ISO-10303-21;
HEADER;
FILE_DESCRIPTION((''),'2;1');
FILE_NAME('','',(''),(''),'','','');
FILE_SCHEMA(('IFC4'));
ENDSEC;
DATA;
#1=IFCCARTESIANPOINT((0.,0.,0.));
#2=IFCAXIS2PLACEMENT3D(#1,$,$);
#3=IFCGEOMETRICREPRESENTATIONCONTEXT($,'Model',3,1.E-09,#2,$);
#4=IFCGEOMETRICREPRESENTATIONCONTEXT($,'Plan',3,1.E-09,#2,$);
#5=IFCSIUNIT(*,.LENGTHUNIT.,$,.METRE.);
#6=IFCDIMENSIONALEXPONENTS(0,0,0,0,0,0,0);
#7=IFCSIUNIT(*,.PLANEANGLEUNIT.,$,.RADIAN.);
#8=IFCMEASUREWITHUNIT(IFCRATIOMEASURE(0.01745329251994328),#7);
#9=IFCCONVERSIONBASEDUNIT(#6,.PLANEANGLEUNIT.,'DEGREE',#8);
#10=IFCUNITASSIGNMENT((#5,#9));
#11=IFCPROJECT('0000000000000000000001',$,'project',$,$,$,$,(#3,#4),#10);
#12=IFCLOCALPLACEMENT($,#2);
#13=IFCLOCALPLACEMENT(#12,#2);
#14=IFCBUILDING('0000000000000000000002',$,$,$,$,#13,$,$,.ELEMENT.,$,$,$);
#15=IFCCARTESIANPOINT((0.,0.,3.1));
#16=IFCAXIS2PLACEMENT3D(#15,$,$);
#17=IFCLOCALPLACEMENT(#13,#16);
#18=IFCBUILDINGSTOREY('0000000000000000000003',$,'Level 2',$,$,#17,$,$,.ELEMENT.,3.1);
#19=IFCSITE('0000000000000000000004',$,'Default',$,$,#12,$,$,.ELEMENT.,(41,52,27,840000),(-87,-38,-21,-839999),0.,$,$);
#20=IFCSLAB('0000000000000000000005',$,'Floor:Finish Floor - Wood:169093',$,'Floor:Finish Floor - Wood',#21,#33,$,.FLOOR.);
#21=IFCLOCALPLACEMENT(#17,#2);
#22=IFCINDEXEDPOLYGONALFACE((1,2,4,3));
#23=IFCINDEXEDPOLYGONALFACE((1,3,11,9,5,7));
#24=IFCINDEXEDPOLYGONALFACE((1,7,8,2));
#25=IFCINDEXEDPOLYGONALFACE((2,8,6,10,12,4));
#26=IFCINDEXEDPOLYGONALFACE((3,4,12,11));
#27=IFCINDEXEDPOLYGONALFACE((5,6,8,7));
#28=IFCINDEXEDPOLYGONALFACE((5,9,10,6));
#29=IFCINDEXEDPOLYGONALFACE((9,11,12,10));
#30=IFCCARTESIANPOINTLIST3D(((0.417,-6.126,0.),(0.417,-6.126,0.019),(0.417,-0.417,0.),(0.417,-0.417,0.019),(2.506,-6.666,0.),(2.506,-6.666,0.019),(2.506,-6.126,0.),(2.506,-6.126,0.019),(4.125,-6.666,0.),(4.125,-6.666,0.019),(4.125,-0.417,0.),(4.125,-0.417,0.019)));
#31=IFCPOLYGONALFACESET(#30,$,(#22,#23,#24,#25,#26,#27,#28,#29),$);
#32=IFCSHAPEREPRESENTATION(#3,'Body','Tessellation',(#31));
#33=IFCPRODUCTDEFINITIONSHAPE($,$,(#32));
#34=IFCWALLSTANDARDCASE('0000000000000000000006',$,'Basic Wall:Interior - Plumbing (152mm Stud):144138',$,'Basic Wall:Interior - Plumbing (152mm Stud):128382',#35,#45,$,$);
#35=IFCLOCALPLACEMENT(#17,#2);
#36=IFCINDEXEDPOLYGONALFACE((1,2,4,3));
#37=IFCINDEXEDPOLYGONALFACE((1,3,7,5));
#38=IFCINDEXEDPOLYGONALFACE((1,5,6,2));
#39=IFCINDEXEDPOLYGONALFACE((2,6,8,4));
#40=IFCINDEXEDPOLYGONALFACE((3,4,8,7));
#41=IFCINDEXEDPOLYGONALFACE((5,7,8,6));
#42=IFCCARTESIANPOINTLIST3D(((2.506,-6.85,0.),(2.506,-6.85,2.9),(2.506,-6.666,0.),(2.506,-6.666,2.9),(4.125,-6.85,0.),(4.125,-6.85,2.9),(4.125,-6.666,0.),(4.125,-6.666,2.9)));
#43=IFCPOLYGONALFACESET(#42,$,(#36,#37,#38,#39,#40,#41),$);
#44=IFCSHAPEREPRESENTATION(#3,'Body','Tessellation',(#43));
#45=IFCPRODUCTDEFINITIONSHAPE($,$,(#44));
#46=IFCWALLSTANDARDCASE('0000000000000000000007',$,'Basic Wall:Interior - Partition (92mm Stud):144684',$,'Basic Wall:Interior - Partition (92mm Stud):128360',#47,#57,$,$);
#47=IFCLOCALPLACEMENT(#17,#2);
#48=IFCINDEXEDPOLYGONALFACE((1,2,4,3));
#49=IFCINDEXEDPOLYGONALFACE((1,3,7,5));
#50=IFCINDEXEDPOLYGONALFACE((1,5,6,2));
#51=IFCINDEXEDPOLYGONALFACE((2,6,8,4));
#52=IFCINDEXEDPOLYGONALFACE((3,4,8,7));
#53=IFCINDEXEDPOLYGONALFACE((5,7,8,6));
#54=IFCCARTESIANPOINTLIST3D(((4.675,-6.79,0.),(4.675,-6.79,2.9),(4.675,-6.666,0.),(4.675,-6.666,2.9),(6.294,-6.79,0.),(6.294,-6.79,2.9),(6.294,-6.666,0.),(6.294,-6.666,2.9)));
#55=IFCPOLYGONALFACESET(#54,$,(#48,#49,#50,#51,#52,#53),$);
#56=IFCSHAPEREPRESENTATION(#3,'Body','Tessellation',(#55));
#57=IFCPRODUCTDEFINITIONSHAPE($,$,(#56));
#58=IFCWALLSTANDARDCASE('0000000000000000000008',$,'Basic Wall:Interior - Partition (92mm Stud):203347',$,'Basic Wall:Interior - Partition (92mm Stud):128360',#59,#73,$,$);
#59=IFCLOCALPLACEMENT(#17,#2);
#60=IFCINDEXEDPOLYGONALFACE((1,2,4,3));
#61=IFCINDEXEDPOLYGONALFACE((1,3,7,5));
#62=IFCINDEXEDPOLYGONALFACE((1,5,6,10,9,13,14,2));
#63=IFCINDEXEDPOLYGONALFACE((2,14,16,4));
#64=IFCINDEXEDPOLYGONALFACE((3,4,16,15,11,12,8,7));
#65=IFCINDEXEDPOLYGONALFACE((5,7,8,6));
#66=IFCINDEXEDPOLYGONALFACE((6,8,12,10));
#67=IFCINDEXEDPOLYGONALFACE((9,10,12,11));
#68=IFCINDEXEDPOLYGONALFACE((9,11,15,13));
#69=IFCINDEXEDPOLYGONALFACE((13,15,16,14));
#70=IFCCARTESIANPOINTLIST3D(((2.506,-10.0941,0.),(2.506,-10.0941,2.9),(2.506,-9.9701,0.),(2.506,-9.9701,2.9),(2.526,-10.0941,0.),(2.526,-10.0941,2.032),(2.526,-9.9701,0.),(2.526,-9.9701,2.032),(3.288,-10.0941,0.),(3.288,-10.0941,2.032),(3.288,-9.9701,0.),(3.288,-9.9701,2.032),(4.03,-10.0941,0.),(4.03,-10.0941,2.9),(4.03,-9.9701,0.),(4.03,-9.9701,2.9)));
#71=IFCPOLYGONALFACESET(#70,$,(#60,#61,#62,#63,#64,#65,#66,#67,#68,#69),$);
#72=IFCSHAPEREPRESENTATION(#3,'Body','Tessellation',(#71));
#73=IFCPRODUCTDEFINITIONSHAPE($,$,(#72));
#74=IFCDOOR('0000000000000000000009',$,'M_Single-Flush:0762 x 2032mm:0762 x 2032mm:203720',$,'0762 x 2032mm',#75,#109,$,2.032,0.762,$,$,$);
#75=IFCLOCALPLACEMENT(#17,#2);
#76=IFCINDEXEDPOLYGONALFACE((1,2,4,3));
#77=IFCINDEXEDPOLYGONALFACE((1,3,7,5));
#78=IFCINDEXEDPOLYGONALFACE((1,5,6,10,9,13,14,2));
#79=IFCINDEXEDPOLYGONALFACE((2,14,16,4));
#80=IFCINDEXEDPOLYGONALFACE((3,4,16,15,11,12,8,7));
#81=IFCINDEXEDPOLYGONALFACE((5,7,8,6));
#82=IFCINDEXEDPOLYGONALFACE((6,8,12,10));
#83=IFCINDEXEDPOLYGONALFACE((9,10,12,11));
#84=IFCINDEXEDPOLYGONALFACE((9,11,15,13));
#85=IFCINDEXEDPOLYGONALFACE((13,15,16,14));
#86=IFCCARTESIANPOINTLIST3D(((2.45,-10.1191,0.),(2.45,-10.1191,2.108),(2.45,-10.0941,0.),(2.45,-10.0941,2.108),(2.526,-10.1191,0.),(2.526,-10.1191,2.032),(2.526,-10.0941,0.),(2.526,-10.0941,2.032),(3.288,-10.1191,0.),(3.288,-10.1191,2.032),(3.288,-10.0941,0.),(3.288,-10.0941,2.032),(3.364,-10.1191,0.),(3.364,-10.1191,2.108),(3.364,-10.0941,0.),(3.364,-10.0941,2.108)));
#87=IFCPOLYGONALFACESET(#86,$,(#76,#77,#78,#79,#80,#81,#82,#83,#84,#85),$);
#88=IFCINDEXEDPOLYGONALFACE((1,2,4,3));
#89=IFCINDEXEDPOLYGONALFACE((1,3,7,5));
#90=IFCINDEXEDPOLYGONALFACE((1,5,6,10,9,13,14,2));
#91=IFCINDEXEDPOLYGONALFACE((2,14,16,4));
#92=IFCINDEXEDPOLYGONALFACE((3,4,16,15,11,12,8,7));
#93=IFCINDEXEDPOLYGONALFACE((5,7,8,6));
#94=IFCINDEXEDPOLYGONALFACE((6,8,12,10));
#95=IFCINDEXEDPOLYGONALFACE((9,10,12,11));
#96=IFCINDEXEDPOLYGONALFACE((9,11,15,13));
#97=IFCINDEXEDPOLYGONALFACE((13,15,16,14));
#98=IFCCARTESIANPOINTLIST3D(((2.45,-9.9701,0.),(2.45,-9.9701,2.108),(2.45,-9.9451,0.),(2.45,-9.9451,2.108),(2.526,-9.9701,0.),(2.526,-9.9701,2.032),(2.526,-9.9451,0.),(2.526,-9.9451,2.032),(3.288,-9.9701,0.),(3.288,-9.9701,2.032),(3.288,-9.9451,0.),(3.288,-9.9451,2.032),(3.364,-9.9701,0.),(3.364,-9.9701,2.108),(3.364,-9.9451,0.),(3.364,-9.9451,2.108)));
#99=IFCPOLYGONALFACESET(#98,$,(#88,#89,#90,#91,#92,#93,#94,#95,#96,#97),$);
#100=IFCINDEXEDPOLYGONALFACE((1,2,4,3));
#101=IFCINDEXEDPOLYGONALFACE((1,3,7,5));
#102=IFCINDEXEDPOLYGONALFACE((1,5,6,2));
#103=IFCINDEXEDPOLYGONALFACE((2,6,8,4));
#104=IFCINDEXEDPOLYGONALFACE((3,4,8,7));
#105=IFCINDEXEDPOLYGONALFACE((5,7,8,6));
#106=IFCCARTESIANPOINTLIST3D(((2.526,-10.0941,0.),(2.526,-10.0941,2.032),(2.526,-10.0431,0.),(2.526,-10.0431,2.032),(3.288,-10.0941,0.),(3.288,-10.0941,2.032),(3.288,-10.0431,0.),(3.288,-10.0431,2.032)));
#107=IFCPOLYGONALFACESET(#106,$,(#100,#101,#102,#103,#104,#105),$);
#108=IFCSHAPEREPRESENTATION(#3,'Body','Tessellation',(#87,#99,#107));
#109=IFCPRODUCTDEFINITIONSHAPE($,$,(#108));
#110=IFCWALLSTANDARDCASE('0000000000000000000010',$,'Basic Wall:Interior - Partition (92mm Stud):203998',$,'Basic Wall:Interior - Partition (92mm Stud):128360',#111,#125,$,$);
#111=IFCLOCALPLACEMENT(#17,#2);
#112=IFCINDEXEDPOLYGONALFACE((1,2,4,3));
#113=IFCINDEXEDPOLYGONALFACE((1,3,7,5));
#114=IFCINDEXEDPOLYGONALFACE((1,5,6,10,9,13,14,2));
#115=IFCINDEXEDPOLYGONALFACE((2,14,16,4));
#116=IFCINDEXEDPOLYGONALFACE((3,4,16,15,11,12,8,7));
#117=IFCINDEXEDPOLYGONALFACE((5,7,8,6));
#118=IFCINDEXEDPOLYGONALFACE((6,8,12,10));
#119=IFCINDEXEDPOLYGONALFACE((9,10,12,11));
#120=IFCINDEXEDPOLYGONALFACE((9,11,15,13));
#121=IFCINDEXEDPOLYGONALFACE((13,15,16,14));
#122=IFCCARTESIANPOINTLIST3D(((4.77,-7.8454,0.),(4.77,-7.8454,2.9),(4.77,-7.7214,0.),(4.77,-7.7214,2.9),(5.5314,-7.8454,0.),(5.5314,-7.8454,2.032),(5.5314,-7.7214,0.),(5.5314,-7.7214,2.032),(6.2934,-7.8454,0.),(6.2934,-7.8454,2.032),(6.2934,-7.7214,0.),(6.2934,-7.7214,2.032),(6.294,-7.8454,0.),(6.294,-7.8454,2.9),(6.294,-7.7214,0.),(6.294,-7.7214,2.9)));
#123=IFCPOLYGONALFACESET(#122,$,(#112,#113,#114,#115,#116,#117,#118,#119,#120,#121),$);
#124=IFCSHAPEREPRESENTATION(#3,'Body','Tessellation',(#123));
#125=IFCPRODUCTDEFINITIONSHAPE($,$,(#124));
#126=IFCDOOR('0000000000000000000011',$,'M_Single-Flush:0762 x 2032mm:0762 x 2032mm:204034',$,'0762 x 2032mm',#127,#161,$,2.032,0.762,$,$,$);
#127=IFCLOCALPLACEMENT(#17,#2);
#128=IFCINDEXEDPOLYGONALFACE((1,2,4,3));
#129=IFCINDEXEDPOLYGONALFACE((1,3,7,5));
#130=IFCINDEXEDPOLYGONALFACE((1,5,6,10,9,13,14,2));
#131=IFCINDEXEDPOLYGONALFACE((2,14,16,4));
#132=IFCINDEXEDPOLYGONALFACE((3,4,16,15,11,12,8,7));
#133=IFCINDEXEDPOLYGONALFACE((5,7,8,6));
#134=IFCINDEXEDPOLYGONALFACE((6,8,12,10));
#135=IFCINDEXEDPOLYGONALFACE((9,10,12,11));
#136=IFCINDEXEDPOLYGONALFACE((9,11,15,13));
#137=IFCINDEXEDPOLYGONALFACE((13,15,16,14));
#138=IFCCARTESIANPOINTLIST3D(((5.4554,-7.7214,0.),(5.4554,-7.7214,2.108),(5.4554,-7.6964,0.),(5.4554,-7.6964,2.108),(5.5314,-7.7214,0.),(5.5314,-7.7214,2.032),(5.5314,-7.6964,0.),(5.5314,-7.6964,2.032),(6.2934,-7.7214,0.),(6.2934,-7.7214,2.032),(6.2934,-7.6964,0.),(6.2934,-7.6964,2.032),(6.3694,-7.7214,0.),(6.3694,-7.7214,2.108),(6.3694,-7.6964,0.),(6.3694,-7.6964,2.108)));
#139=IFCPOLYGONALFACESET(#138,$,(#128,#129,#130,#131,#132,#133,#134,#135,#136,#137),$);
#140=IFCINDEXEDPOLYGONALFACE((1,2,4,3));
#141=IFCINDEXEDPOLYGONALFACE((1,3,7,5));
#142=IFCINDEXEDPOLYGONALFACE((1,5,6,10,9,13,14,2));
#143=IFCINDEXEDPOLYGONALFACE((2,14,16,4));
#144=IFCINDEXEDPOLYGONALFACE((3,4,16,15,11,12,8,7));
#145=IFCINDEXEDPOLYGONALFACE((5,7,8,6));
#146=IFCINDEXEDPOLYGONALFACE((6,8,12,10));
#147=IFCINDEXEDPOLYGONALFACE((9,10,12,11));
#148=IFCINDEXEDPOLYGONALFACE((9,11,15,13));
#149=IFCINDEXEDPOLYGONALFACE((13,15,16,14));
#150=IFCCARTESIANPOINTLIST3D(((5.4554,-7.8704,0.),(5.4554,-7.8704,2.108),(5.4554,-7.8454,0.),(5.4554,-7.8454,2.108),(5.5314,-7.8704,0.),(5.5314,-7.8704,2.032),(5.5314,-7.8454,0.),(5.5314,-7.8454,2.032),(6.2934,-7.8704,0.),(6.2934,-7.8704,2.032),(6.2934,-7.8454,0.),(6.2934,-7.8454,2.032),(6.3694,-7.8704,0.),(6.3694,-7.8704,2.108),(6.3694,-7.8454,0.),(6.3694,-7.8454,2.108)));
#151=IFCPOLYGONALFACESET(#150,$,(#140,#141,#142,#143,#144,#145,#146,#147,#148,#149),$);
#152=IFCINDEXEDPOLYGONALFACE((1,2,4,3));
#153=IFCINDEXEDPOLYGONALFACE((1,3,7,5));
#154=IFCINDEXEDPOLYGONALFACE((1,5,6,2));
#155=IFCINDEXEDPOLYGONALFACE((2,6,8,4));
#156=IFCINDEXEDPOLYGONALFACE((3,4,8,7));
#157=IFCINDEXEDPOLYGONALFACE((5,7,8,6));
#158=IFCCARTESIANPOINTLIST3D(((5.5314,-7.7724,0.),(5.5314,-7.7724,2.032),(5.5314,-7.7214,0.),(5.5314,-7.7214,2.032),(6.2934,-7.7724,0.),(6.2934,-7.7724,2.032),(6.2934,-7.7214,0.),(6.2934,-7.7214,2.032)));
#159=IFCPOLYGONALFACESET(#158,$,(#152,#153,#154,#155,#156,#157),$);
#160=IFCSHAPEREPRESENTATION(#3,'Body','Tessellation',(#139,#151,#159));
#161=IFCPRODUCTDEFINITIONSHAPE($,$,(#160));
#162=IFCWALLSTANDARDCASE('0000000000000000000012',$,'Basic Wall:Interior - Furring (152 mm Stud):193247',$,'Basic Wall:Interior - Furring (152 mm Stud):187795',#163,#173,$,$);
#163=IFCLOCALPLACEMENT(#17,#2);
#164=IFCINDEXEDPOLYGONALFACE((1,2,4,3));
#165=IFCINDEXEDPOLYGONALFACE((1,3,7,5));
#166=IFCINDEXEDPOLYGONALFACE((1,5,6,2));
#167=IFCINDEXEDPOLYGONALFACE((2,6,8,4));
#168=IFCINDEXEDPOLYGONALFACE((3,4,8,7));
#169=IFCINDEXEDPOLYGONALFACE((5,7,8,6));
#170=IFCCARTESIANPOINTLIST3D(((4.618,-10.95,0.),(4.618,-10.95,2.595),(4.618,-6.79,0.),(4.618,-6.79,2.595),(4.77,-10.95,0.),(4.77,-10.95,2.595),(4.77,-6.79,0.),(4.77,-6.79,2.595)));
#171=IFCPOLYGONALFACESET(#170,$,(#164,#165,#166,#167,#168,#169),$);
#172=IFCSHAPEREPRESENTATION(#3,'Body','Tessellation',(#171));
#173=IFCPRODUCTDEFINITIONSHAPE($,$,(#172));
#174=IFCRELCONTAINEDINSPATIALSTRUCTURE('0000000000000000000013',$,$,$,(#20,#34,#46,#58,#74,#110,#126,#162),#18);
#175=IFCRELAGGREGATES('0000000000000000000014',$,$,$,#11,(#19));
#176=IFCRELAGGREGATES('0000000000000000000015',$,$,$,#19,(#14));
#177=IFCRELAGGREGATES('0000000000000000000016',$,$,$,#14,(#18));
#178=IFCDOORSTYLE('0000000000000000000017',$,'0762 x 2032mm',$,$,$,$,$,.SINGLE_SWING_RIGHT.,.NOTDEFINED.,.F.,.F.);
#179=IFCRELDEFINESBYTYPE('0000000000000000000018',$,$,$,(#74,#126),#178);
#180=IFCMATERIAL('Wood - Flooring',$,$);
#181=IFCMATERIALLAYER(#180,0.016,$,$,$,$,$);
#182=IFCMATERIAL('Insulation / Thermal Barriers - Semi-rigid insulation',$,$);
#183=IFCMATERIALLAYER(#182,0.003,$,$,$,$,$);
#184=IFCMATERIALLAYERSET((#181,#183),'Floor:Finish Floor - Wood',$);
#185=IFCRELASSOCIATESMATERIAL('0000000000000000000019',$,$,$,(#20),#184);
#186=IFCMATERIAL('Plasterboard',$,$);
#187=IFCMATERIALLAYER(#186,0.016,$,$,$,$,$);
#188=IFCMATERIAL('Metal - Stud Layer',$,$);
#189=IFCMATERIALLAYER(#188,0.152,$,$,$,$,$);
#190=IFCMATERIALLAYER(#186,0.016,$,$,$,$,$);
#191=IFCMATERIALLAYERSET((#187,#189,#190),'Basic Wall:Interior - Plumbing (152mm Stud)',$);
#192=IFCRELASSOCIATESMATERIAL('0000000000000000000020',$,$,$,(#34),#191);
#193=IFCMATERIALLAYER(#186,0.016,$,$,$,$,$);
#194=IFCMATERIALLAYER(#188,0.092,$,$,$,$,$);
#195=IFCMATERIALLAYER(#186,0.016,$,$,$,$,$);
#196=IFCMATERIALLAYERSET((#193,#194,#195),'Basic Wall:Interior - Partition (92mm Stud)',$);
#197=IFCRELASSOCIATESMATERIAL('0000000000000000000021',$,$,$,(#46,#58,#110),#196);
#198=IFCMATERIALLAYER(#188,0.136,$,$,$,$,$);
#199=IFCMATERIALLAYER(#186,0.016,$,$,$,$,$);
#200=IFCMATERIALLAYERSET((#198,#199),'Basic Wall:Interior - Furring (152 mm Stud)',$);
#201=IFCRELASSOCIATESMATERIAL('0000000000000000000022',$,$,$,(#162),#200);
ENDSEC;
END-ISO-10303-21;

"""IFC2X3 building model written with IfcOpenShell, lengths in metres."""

from ifc_helpers import new_model, entity, si_unit, converted_unit, frame, frame_2d, origin, origin_2d_with_axis, place, context, project, spatial, polyline, rectangle, outline, extrude, source, transform, mapped, material, layer, layer_set, layer_usage, type_object, type_shapes, element, fill, save


model = new_model("IFC2X3")

# Units and contexts
model_context = context("Model", 3, precision=1e-09, world=origin())
plan_context = context("Plan", 3, precision=1e-09, world=origin())
ifc_project = project(units=[si_unit("LENGTHUNIT", "METRE"), converted_unit("PLANEANGLEUNIT", "DEGREE", entity("IfcRatioMeasure", 0.01745329251994328), si_unit("PLANEANGLEUNIT", "RADIAN"), dimensions=[0, 0, 0, 0, 0, 0, 0])], contexts=[model_context, plan_context])

# Site, building, storey
site_placement = place(None, origin())
site = spatial("IfcSite", under=ifc_project, at=site_placement, Name="Default", CompositionType="ELEMENT", RefLatitude=(41, 52, 27, 840000), RefLongitude=(-87, -38, -21, -839999), RefElevation=0.0)
building_placement = place(site_placement, origin())
building = spatial("IfcBuilding", under=site, at=building_placement, CompositionType="ELEMENT")
storey_placement = place(building_placement, frame((0.0, 0.0, 3.1)))
storey = spatial("IfcBuildingStorey", under=building, at=storey_placement, Name="Level 2", CompositionType="ELEMENT", Elevation=3.1)

# Slab
ifc_material_1 = material(Name="Wood - Flooring")
ifc_layer_1 = layer(ifc_material_1, 0.016)
ifc_material_2 = material(Name="Insulation / Thermal Barriers - Semi-rigid insulation")
ifc_layer_2 = layer(ifc_material_2, 0.003)
ifc_layer_set_1 = layer_set([ifc_layer_1, ifc_layer_2], Name="Floor:Finish Floor - Wood")
ifc_layer_usage_1 = layer_usage(ifc_layer_set_1, "AXIS3", "POSITIVE", 0.0)
slab_placement = place(storey_placement, frame((0.417, -6.666, 0.0)))
element("IfcSlab", 1, at=slab_placement, inside=storey, material=ifc_layer_usage_1, Name="Floor:Finish Floor - Wood:169093", ObjectType="Floor:Finish Floor - Wood", PredefinedType="FLOOR", context=model_context, shape_type="SweptSolid", body=[
    extrude(outline(polyline([(1.854, 3.1245), (-1.854, 3.1245), (-1.854, -3.1245), (-0.235, -3.1245), (-0.235, -2.5845), (1.854, -2.5845), (1.854, 3.1245)])), frame((1.854, 3.1245, 0.019), z_axis=(0.0, 0.0, -1.0), x_axis=(-1.0, 0.0, 0.0)), (0.0, 0.0, 1.0), 0.019),
])

# Walls
ifc_material_3 = material(Name="Plasterboard")
ifc_layer_3 = layer(ifc_material_3, 0.016)
ifc_material_4 = material(Name="Metal - Stud Layer")
ifc_layer_4 = layer(ifc_material_4, 0.152)
ifc_layer_5 = layer(ifc_material_3, 0.016)
ifc_layer_set_2 = layer_set([ifc_layer_3, ifc_layer_4, ifc_layer_5], Name="Basic Wall:Interior - Plumbing (152mm Stud)")
ifc_layer_usage_2 = layer_usage(ifc_layer_set_2, "AXIS2", "NEGATIVE", 0.092)
wall_1_placement = place(storey_placement, frame((2.506, -6.758, 0.0)))
element("IfcWallStandardCase", 2, at=wall_1_placement, inside=storey, material=ifc_layer_usage_2, Name="Basic Wall:Interior - Plumbing (152mm Stud):144138", ObjectType="Basic Wall:Interior - Plumbing (152mm Stud):128382", context=model_context, shape_type="SweptSolid", body=[
    extrude(rectangle(XDim=1.619, YDim=0.184, at=frame_2d((0.8095, 0.0), x_axis=(-1.0, 0.0))), origin(), (0.0, 0.0, 1.0), 2.9),
])
ifc_layer_6 = layer(ifc_material_3, 0.016)
ifc_layer_7 = layer(ifc_material_4, 0.092)
ifc_layer_8 = layer(ifc_material_3, 0.016)
ifc_layer_set_3 = layer_set([ifc_layer_6, ifc_layer_7, ifc_layer_8], Name="Basic Wall:Interior - Partition (92mm Stud)")
ifc_layer_usage_3 = layer_usage(ifc_layer_set_3, "AXIS2", "NEGATIVE", 0.062)
wall_2_placement = place(storey_placement, frame((4.675, -6.728, 0.0)))
element("IfcWallStandardCase", 3, at=wall_2_placement, inside=storey, material=ifc_layer_usage_3, Name="Basic Wall:Interior - Partition (92mm Stud):144684", ObjectType="Basic Wall:Interior - Partition (92mm Stud):128360", context=model_context, shape_type="SweptSolid", body=[
    extrude(rectangle(XDim=1.619, YDim=0.124, at=frame_2d((0.8095, 0.0), x_axis=(-1.0, 0.0))), origin(), (0.0, 0.0, 1.0), 2.9),
])

# Walls, openings, doors
wall_3_placement = place(storey_placement, frame((4.03, -10.0321, 0.0), z_axis=(0.0, 0.0, 1.0), x_axis=(-1.0, 0.0, 0.0)))
wall_3 = element("IfcWallStandardCase", 4, at=wall_3_placement, inside=storey, material=ifc_layer_usage_3, Name="Basic Wall:Interior - Partition (92mm Stud):203347", ObjectType="Basic Wall:Interior - Partition (92mm Stud):128360", context=model_context, shape_type="SweptSolid", body=[
    extrude(rectangle(XDim=1.524, YDim=0.124, at=frame_2d((0.762, 0.0), x_axis=(-1.0, 0.0))), origin(), (0.0, 0.0, 1.0), 2.9),
])
opening_1_placement = place(wall_3_placement, frame((0.742, -0.062, 0.0)))
opening_1 = element("IfcOpeningElement", 5, at=opening_1_placement, cuts=wall_3, ObjectType="Opening", context=model_context, shape_type="SweptSolid", body=[
    extrude(rectangle(XDim=0.762, YDim=2.032, at=frame_2d((1.016, 0.381), x_axis=(0.0, 1.0))), frame((0.0, 0.0, 0.0), z_axis=(0.0, 1.0, 0.0), x_axis=(0.0, 0.0, 1.0)), (0.0, 0.0, 1.0), 0.124),
])
door_style = type_object("IfcDoorStyle", Name="0762 x 2032mm", ConstructionType="NOTDEFINED", OperationType="SINGLE_SWING_RIGHT", ParameterTakesPrecedence=False, Sizeable=False)
shared_shape = source(origin(), model_context, "Body", "SweptSolid", [
    extrude(outline(polyline([(-0.457, -1.073), (0.457, -1.073), (0.457, 1.035), (0.381, 1.035), (0.381, -0.997), (-0.381, -0.997), (-0.381, 1.035), (-0.457, 1.035), (-0.457, -1.073)])), frame((0.381, 0.124, 1.035), z_axis=(0.0, 1.0, 0.0), x_axis=(1.0, 0.0, 0.0)), (0.0, 0.0, 1.0), 0.025),
    extrude(outline(polyline([(-1.073, -0.457), (1.035, -0.457), (1.035, -0.381), (-0.997, -0.381), (-0.997, 0.381), (1.035, 0.381), (1.035, 0.457), (-1.073, 0.457), (-1.073, -0.457)])), frame((0.381, -0.025, 1.035), z_axis=(0.0, 1.0, 0.0), x_axis=(0.0, 0.0, -1.0)), (0.0, 0.0, 1.0), 0.025),
    extrude(rectangle(XDim=0.051, YDim=0.762, at=origin_2d_with_axis()), frame((0.381, 0.0985, 0.0), z_axis=(0.0, 0.0, 1.0), x_axis=(0.0, 1.0, 0.0)), (0.0, 0.0, 1.0), 2.032),
])
type_shapes(door_style, [shared_shape])
door_1_placement = place(opening_1_placement, origin())
door_1 = element("IfcDoor", 6, at=door_1_placement, inside=storey, type_object=door_style, Name="M_Single-Flush:0762 x 2032mm:0762 x 2032mm:203720", ObjectType="0762 x 2032mm", OverallHeight=2.032, OverallWidth=0.762, context=model_context, shape_type="MappedRepresentation", body=[
    mapped(shared_shape, transform((0.0, 0.0, 0.0), scale=1.0)),
])
fill(opening_1, door_1)
ifc_layer_usage_4 = layer_usage(ifc_layer_set_3, "AXIS2", "POSITIVE", -0.062)
wall_4_placement = place(storey_placement, frame((4.77, -7.7834, 0.0)))
wall_4 = element("IfcWallStandardCase", 7, at=wall_4_placement, inside=storey, material=ifc_layer_usage_4, Name="Basic Wall:Interior - Partition (92mm Stud):203998", ObjectType="Basic Wall:Interior - Partition (92mm Stud):128360", context=model_context, shape_type="SweptSolid", body=[
    extrude(rectangle(XDim=1.524, YDim=0.124, at=frame_2d((0.762, 0.0), x_axis=(-1.0, 0.0))), origin(), (0.0, 0.0, 1.0), 2.9),
])
opening_2_placement = place(wall_4_placement, frame((0.7614, -0.062, 0.0)))
opening_2 = element("IfcOpeningElement", 8, at=opening_2_placement, cuts=wall_4, ObjectType="Opening", context=model_context, shape_type="SweptSolid", body=[
    extrude(rectangle(XDim=0.762, YDim=2.032, at=frame_2d((1.016, 0.381), x_axis=(0.0, 1.0))), frame((0.0, 0.0, 0.0), z_axis=(0.0, 1.0, 0.0), x_axis=(0.0, 0.0, 1.0)), (0.0, 0.0, 1.0), 0.124),
])
door_2_placement = place(opening_2_placement, origin())
door_2 = element("IfcDoor", 9, at=door_2_placement, inside=storey, type_object=door_style, Name="M_Single-Flush:0762 x 2032mm:0762 x 2032mm:204034", ObjectType="0762 x 2032mm", OverallHeight=2.032, OverallWidth=0.762, context=model_context, shape_type="MappedRepresentation", body=[
    mapped(shared_shape, transform((0.0, 0.0, 0.0), scale=1.0)),
])
fill(opening_2, door_2)

# Wall
ifc_layer_9 = layer(ifc_material_4, 0.136)
ifc_layer_10 = layer(ifc_material_3, 0.016)
ifc_layer_set_4 = layer_set([ifc_layer_9, ifc_layer_10], Name="Basic Wall:Interior - Furring (152 mm Stud)")
ifc_layer_usage_5 = layer_usage(ifc_layer_set_4, "AXIS2", "POSITIVE", -0.076)
wall_5_placement = place(storey_placement, frame((4.694, -6.79, 0.0), z_axis=(0.0, 0.0, 1.0), x_axis=(0.0, -1.0, 0.0)))
element("IfcWallStandardCase", 10, at=wall_5_placement, inside=storey, material=ifc_layer_usage_5, Name="Basic Wall:Interior - Furring (152 mm Stud):193247", ObjectType="Basic Wall:Interior - Furring (152 mm Stud):187795", context=model_context, shape_type="SweptSolid", body=[
    extrude(rectangle(XDim=4.16, YDim=0.152, at=frame_2d((2.08, 0.0), x_axis=(-1.0, 0.0))), origin(), (0.0, 0.0, 1.0), 2.595),
])

save(model, "model.ifc")
